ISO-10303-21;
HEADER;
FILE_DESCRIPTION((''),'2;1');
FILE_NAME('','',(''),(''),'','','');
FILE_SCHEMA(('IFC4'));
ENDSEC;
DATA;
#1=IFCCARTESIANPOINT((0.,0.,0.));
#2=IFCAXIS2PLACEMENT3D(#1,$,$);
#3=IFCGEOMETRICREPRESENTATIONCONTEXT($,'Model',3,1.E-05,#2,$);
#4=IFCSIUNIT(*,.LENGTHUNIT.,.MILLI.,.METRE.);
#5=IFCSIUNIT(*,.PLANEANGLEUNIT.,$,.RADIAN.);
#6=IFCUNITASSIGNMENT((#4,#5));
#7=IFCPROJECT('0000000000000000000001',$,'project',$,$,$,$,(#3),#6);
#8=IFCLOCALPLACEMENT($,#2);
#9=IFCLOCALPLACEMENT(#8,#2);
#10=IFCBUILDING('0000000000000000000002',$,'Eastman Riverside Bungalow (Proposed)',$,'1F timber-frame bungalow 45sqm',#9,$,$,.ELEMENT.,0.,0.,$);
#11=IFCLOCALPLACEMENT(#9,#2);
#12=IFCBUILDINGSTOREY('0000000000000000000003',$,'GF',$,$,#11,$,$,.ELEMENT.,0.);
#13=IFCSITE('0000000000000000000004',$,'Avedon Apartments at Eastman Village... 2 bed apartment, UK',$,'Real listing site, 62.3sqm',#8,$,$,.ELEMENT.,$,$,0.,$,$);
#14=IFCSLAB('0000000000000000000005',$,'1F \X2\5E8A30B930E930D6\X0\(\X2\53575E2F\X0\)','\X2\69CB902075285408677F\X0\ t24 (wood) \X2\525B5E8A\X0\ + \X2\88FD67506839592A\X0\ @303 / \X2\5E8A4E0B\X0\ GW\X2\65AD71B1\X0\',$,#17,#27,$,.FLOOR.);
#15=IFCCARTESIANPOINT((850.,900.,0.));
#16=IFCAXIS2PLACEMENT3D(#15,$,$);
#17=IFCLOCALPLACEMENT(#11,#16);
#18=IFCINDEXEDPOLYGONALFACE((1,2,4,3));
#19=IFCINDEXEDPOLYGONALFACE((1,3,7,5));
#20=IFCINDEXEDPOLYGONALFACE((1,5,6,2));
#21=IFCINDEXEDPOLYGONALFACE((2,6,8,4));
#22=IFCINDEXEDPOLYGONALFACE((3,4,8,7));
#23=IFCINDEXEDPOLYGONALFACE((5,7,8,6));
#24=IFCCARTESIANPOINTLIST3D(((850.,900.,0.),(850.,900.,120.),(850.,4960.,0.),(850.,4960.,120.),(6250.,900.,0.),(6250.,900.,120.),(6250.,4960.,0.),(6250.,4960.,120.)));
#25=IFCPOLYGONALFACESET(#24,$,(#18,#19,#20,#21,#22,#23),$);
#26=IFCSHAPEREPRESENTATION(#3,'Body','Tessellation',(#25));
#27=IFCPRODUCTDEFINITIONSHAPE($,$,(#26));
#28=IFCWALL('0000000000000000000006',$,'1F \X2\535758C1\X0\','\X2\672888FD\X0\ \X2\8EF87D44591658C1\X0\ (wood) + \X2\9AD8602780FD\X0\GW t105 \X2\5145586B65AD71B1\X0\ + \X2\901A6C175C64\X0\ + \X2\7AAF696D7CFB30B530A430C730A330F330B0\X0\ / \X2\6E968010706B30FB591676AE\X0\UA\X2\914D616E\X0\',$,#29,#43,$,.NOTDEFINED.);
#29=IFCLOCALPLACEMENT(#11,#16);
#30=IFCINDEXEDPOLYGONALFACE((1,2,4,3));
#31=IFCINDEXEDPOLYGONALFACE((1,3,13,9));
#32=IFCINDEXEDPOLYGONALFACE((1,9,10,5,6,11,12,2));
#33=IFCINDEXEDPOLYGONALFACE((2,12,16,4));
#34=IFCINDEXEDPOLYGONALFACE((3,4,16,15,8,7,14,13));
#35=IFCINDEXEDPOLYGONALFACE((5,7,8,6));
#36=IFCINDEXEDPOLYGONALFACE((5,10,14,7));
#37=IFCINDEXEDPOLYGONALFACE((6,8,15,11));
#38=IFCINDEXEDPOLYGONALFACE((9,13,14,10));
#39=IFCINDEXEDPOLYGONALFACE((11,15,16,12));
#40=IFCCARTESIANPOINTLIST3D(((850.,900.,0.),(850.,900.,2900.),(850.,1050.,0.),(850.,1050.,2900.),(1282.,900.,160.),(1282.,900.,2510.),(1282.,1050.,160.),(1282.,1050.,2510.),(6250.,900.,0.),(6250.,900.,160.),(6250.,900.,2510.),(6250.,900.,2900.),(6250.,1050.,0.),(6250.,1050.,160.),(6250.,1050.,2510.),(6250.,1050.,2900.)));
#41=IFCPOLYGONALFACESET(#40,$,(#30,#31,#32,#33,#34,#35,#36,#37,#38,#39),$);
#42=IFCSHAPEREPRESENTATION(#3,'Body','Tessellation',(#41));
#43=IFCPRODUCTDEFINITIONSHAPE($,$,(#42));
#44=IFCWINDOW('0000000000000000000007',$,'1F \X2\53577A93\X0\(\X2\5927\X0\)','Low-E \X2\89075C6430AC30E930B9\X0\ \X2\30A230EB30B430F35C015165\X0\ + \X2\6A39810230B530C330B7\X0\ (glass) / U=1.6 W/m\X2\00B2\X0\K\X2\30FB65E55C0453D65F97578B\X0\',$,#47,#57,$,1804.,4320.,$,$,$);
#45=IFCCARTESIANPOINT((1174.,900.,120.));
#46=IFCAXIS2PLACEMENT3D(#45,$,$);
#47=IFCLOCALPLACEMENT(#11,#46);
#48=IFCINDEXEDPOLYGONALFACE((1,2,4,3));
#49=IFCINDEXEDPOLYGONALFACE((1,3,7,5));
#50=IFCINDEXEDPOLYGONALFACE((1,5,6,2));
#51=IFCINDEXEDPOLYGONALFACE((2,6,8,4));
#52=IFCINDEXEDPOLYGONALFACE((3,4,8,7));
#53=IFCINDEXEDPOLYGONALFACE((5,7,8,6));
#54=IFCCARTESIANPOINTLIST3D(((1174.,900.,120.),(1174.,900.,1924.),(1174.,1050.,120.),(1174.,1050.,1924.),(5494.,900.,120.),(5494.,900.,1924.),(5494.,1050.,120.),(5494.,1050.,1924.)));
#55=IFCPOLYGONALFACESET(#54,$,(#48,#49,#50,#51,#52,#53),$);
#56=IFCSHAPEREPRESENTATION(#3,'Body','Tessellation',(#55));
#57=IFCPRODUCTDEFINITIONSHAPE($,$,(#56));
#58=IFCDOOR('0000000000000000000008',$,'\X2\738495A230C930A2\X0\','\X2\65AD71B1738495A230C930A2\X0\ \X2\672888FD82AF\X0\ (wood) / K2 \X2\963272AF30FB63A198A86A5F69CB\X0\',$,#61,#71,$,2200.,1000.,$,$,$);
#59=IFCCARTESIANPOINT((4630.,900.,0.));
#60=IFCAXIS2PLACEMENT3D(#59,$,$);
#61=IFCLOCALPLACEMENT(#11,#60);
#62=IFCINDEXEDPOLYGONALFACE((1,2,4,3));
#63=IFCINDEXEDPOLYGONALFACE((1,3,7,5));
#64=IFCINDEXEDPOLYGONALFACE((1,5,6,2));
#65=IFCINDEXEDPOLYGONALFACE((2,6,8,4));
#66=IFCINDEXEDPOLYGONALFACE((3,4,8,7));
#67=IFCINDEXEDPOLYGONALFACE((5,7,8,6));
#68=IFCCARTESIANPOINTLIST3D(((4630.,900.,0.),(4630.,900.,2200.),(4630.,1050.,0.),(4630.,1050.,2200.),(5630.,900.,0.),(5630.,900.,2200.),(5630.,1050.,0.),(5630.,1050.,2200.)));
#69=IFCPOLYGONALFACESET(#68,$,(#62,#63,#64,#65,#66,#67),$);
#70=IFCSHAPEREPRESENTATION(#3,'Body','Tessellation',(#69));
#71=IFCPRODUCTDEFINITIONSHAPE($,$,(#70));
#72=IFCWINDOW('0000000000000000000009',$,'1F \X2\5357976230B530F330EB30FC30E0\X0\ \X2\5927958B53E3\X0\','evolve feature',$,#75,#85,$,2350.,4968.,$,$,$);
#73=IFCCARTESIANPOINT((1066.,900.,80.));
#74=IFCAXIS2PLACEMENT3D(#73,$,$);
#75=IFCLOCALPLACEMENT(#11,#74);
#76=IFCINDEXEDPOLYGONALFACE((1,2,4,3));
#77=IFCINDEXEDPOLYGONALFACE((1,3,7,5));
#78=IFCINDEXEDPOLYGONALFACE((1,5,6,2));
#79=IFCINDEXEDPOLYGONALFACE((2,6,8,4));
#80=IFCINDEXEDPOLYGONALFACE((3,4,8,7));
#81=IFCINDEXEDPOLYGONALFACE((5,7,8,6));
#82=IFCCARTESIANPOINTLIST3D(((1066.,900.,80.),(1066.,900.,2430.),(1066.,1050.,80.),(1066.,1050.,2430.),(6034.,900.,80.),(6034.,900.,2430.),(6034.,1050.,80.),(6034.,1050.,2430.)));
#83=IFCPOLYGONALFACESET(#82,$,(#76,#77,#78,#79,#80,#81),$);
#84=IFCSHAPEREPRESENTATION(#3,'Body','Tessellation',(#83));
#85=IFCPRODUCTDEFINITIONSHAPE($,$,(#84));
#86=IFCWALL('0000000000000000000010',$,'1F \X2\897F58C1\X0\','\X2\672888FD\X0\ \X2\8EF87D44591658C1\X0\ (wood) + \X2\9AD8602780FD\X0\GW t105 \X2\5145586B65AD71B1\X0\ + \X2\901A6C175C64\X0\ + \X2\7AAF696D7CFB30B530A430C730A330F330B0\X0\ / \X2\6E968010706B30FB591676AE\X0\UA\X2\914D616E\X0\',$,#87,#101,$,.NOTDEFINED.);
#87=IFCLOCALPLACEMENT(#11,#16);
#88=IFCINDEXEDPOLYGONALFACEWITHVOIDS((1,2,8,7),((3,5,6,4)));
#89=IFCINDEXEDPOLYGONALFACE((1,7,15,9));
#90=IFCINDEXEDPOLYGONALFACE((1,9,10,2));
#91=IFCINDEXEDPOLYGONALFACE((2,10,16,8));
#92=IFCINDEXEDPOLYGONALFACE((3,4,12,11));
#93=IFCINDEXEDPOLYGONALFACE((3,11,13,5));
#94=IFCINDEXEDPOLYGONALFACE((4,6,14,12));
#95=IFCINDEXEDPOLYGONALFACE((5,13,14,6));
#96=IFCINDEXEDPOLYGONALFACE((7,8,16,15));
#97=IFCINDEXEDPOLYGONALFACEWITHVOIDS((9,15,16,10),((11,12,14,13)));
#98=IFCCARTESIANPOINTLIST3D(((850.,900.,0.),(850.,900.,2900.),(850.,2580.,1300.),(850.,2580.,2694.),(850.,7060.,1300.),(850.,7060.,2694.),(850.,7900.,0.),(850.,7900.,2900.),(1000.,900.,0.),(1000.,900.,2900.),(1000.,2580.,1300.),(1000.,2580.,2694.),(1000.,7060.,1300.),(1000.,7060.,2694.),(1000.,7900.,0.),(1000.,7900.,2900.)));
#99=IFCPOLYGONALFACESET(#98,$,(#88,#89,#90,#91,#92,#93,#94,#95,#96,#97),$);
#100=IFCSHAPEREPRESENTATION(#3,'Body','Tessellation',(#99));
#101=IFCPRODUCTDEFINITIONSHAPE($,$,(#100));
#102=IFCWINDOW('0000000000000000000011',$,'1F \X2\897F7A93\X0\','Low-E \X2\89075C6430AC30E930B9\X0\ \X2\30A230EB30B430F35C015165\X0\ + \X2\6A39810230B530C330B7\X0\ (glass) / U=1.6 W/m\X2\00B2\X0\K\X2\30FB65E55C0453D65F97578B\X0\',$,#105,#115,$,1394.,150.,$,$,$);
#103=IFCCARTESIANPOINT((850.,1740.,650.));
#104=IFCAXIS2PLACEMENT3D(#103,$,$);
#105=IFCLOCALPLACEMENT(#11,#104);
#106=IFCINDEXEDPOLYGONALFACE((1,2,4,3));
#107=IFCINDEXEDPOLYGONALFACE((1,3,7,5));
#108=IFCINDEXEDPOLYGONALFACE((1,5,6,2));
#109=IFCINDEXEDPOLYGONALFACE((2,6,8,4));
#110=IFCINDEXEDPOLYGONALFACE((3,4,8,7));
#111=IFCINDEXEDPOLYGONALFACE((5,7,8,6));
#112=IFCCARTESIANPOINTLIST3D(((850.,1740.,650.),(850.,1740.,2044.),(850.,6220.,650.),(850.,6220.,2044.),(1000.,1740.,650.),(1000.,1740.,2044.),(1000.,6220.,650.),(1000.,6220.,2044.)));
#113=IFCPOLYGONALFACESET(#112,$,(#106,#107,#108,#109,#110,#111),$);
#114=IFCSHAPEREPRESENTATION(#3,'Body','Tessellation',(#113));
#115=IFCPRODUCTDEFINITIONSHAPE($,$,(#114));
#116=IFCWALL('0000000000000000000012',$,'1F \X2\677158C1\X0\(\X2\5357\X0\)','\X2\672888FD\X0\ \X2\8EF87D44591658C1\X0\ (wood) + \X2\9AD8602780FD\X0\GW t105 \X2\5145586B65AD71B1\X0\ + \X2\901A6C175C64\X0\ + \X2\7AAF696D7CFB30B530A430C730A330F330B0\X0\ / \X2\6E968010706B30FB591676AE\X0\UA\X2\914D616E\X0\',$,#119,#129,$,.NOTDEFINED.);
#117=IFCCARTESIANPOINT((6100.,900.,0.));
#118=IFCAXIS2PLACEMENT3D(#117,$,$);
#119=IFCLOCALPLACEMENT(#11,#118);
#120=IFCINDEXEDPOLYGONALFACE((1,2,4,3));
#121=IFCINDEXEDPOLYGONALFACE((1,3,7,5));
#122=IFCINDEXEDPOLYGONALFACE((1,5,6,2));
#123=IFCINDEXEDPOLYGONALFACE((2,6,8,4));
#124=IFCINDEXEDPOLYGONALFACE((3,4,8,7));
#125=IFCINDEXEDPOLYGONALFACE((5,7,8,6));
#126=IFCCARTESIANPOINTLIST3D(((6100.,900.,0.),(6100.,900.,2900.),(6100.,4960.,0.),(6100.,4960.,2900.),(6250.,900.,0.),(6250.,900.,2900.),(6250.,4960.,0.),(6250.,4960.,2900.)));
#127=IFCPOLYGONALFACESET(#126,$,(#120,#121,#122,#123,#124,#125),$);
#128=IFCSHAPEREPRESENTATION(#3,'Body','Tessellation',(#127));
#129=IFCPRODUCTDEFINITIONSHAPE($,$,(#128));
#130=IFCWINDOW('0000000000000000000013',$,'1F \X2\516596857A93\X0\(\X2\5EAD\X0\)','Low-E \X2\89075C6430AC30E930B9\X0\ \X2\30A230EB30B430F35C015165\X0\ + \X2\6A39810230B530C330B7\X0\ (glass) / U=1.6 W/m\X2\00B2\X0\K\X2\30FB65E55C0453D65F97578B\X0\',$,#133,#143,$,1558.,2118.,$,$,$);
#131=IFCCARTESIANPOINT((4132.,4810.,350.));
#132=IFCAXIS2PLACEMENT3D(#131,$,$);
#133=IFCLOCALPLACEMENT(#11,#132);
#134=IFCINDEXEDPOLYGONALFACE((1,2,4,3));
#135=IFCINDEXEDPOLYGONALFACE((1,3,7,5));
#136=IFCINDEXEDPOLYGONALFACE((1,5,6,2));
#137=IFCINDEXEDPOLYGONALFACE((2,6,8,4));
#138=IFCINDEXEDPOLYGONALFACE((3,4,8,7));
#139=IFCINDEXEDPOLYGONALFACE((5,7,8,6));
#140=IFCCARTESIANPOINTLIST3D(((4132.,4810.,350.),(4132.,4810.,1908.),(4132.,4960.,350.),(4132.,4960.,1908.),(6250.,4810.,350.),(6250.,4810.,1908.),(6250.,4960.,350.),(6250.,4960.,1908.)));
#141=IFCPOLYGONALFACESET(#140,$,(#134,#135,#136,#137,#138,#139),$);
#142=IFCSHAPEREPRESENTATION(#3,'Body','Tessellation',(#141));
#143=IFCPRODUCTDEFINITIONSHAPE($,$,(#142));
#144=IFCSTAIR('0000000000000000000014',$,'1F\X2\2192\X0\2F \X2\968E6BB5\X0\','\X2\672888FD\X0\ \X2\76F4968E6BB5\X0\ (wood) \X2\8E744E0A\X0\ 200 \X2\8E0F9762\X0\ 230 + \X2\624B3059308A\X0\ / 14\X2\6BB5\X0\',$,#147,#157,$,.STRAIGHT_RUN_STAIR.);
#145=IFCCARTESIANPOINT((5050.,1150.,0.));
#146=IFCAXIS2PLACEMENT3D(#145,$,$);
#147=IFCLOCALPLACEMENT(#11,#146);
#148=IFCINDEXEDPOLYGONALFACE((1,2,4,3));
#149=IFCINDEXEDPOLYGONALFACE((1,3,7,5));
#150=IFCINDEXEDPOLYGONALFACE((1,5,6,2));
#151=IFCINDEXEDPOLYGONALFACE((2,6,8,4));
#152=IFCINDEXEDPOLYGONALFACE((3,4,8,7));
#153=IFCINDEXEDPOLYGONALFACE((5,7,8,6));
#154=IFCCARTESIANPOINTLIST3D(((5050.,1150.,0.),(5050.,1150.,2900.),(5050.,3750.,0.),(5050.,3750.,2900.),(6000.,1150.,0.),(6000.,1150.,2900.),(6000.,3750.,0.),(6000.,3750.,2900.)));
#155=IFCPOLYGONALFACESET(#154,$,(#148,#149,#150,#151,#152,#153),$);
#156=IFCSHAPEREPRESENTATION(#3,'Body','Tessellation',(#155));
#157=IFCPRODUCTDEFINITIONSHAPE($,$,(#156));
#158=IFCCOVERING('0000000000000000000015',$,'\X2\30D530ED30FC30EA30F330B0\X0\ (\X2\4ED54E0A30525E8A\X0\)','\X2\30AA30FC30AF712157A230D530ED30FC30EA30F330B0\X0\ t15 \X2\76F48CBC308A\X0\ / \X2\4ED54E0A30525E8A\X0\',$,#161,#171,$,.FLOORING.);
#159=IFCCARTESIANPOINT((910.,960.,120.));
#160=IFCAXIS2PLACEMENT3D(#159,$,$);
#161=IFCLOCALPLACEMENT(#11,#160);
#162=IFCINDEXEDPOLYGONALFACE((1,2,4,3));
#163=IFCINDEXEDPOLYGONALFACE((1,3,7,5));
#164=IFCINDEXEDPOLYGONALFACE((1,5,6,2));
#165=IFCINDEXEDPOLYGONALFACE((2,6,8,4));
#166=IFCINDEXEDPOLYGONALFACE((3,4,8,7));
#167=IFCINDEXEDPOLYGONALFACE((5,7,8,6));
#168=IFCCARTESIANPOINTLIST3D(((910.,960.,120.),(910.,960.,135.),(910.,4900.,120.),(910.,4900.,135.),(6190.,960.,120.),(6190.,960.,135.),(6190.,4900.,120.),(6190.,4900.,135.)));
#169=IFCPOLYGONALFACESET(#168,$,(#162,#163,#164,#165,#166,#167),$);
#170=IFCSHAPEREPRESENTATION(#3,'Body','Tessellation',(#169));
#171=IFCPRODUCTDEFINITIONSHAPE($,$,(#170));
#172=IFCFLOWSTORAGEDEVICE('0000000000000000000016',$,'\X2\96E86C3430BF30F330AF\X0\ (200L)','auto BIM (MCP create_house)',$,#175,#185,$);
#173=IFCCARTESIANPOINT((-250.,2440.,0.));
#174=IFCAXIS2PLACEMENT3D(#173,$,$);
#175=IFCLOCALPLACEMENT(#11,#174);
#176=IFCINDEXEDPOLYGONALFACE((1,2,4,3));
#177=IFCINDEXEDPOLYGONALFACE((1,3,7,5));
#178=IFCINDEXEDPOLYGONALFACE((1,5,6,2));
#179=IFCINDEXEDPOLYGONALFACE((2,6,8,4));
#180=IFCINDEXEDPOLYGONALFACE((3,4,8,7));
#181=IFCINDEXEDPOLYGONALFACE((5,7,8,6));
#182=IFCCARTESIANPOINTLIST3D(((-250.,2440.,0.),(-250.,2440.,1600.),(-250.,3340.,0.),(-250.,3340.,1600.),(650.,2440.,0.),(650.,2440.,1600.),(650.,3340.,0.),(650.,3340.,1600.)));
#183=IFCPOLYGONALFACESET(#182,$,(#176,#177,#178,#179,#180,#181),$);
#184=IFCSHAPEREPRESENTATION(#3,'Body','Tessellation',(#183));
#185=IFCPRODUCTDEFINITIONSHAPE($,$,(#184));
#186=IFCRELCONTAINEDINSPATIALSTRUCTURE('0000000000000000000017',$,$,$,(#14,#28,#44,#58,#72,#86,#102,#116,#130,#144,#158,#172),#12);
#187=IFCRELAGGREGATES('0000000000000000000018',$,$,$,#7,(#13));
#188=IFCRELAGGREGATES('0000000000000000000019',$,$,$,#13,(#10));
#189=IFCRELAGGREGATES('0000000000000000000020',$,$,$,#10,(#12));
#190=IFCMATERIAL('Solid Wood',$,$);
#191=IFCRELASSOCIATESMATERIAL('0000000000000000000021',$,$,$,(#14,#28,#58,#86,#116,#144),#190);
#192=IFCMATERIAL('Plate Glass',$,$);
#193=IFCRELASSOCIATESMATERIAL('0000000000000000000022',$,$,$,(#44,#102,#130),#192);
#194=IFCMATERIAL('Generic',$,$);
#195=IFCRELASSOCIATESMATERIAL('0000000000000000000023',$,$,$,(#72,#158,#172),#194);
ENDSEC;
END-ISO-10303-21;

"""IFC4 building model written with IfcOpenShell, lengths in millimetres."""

from ifc_helpers import new_model, si_unit, frame, frame_2d, origin, place, context, project, spatial, rectangle, extrude, material, element, fill, save


model = new_model("IFC4")

# Units and contexts
model_context = context("Model", 3, precision=1e-05, world=origin())
ifc_project = project(units=[si_unit("LENGTHUNIT", "METRE", prefix="MILLI"), si_unit("PLANEANGLEUNIT", "RADIAN")], contexts=[model_context])

# Site, building, storey
site_placement = place(None, origin())
site = spatial("IfcSite", under=ifc_project, at=site_placement, Name="Avedon Apartments at Eastman Village... 2 bed apartment, UK", ObjectType="Real listing site, 62.3sqm", CompositionType="ELEMENT", RefElevation=0.0)
building_placement = place(site_placement, origin())
building = spatial("IfcBuilding", under=site, at=building_placement, Name="Eastman Riverside Bungalow (Proposed)", ObjectType="1F timber-frame bungalow 45sqm", CompositionType="ELEMENT", ElevationOfRefHeight=0.0, ElevationOfTerrain=0.0)
storey_placement = place(building_placement, origin())
storey = spatial("IfcBuildingStorey", under=building, at=storey_placement, Name="GF", CompositionType="ELEMENT", Elevation=0.0)

# Slab
ifc_material_1 = material(Name="Solid Wood")
slab_1_placement = place(storey_placement, frame((850.0, 900.0, 0.0)))
element("IfcSlab", 1, at=slab_1_placement, inside=storey, material=ifc_material_1, Name="1F 床スラブ(南帯)", Description="構造用合板 t24 (wood) 剛床 + 製材根太 @303 / 床下 GW断熱", PredefinedType="FLOOR", context=model_context, shape_type="SweptSolid", body=[
    extrude(rectangle(XDim=5400.0, YDim=4060.0, at=frame_2d((2700.0, 2030.0))), frame((850.0, 900.0, 0.0)), (0.0, 0.0, 1.0), 120.0),
])

# Wall, openings, windows, door
wall_1_placement = place(storey_placement, frame((850.0, 900.0, 0.0)))
wall_1 = element("IfcWall", 2, at=wall_1_placement, inside=storey, material=ifc_material_1, Name="1F 南壁", Description="木製 軸組外壁 (wood) + 高性能GW t105 充填断熱 + 通気層 + 窯業系サイディング / 準耐火・外皮UA配慮", PredefinedType="NOTDEFINED", context=model_context, shape_type="SweptSolid", body=[
    extrude(rectangle(XDim=5400.0, YDim=150.0, at=frame_2d((2700.0, 75.0))), frame((850.0, 900.0, 0.0)), (0.0, 0.0, 1.0), 2900.0),
])
opening_1_placement = place(storey_placement, frame((1174.0, 900.0, 120.0)))
opening_1 = element("IfcOpeningElement", 3, at=opening_1_placement, cuts=wall_1, PredefinedType="NOTDEFINED", context=model_context, shape_type="SweptSolid", body=[
    extrude(rectangle(XDim=4320.0, YDim=150.0, at=frame_2d((2160.0, 75.0))), frame((1174.0, 900.0, 120.0)), (0.0, 0.0, 1.0), 1804.0),
])
opening_2_placement = place(storey_placement, frame((4630.0, 900.0, 0.0)))
opening_2 = element("IfcOpeningElement", 4, at=opening_2_placement, cuts=wall_1, PredefinedType="NOTDEFINED", context=model_context, shape_type="SweptSolid", body=[
    extrude(rectangle(XDim=1000.0, YDim=150.0, at=frame_2d((500.0, 75.0))), frame((4630.0, 900.0, 0.0)), (0.0, 0.0, 1.0), 2200.0),
])
opening_3_placement = place(storey_placement, frame((1066.0, 900.0, 80.0)))
opening_3 = element("IfcOpeningElement", 5, at=opening_3_placement, cuts=wall_1, PredefinedType="NOTDEFINED", context=model_context, shape_type="SweptSolid", body=[
    extrude(rectangle(XDim=4968.0, YDim=150.0, at=frame_2d((2484.0, 75.0))), frame((1066.0, 900.0, 80.0)), (0.0, 0.0, 1.0), 2350.0),
])
ifc_material_2 = material(Name="Plate Glass")
window_1_placement = place(storey_placement, frame((1174.0, 900.0, 120.0)))
window_1 = element("IfcWindow", 6, at=window_1_placement, inside=storey, material=ifc_material_2, Name="1F 南窓(大)", Description="Low-E 複層ガラス アルゴン封入 + 樹脂サッシ (glass) / U=1.6 W/m²K・日射取得型", OverallHeight=1804.0, OverallWidth=4320.0, context=model_context, shape_type="SweptSolid", body=[
    extrude(rectangle(XDim=4320.0, YDim=150.0, at=frame_2d((2160.0, 75.0))), frame((1174.0, 900.0, 120.0)), (0.0, 0.0, 1.0), 1804.0),
])
fill(opening_1, window_1)
door_1_placement = place(storey_placement, frame((4630.0, 900.0, 0.0)))
door_1 = element("IfcDoor", 7, at=door_1_placement, inside=storey, material=ifc_material_1, Name="玄関ドア", Description="断熱玄関ドア 木製芯 (wood) / K2 防犯・採風機構", OverallHeight=2200.0, OverallWidth=1000.0, context=model_context, shape_type="SweptSolid", body=[
    extrude(rectangle(XDim=1000.0, YDim=150.0, at=frame_2d((500.0, 75.0))), frame((4630.0, 900.0, 0.0)), (0.0, 0.0, 1.0), 2200.0),
])
fill(opening_2, door_1)
ifc_material_3 = material(Name="Generic")
window_2_placement = place(storey_placement, frame((1066.0, 900.0, 80.0)))
window_2 = element("IfcWindow", 8, at=window_2_placement, inside=storey, material=ifc_material_3, Name="1F 南面サンルーム 大開口", Description="evolve feature", OverallHeight=2350.0, OverallWidth=4968.0, context=model_context, shape_type="SweptSolid", body=[
    extrude(rectangle(XDim=4968.0, YDim=150.0, at=frame_2d((2484.0, 75.0))), frame((1066.0, 900.0, 80.0)), (0.0, 0.0, 1.0), 2350.0),
])
fill(opening_3, window_2)

# Walls, openings, windows
wall_2_placement = place(storey_placement, frame((850.0, 900.0, 0.0)))
wall_2 = element("IfcWall", 9, at=wall_2_placement, inside=storey, material=ifc_material_1, Name="1F 西壁", Description="木製 軸組外壁 (wood) + 高性能GW t105 充填断熱 + 通気層 + 窯業系サイディング / 準耐火・外皮UA配慮", PredefinedType="NOTDEFINED", context=model_context, shape_type="SweptSolid", body=[
    extrude(rectangle(XDim=150.0, YDim=7000.0, at=frame_2d((75.0, 3500.0))), frame((850.0, 900.0, 0.0)), (0.0, 0.0, 1.0), 2900.0),
])
opening_4_placement = place(storey_placement, frame((850.0, 1740.0, 650.0)))
opening_4 = element("IfcOpeningElement", 10, at=opening_4_placement, cuts=wall_2, PredefinedType="NOTDEFINED", context=model_context, shape_type="SweptSolid", body=[
    extrude(rectangle(XDim=150.0, YDim=4480.0, at=frame_2d((75.0, 2240.0))), frame((850.0, 1740.0, 650.0)), (0.0, 0.0, 1.0), 1394.0),
])
window_3_placement = place(storey_placement, frame((850.0, 1740.0, 650.0)))
window_3 = element("IfcWindow", 11, at=window_3_placement, inside=storey, material=ifc_material_2, Name="1F 西窓", Description="Low-E 複層ガラス アルゴン封入 + 樹脂サッシ (glass) / U=1.6 W/m²K・日射取得型", OverallHeight=1394.0, OverallWidth=150.0, context=model_context, shape_type="SweptSolid", body=[
    extrude(rectangle(XDim=150.0, YDim=4480.0, at=frame_2d((75.0, 2240.0))), frame((850.0, 1740.0, 650.0)), (0.0, 0.0, 1.0), 1394.0),
])
fill(opening_4, window_3)
wall_3_placement = place(storey_placement, frame((6100.0, 900.0, 0.0)))
wall_3 = element("IfcWall", 12, at=wall_3_placement, inside=storey, material=ifc_material_1, Name="1F 東壁(南)", Description="木製 軸組外壁 (wood) + 高性能GW t105 充填断熱 + 通気層 + 窯業系サイディング / 準耐火・外皮UA配慮", PredefinedType="NOTDEFINED", context=model_context, shape_type="SweptSolid", body=[
    extrude(rectangle(XDim=150.0, YDim=4060.0, at=frame_2d((75.0, 2030.0))), frame((6100.0, 900.0, 0.0)), (0.0, 0.0, 1.0), 2900.0),
])
opening_5_placement = place(storey_placement, frame((4132.0, 4810.0, 350.0)))
opening_5 = element("IfcOpeningElement", 13, at=opening_5_placement, cuts=wall_3, PredefinedType="NOTDEFINED", context=model_context, shape_type="SweptSolid", body=[
    extrude(rectangle(XDim=2118.0, YDim=150.0, at=frame_2d((1059.0, 75.0))), frame((4132.0, 4810.0, 350.0)), (0.0, 0.0, 1.0), 1558.0),
])
window_4_placement = place(storey_placement, frame((4132.0, 4810.0, 350.0)))
window_4 = element("IfcWindow", 14, at=window_4_placement, inside=storey, material=ifc_material_2, Name="1F 入隅窓(庭)", Description="Low-E 複層ガラス アルゴン封入 + 樹脂サッシ (glass) / U=1.6 W/m²K・日射取得型", OverallHeight=1558.0, OverallWidth=2118.0, context=model_context, shape_type="SweptSolid", body=[
    extrude(rectangle(XDim=2118.0, YDim=150.0, at=frame_2d((1059.0, 75.0))), frame((4132.0, 4810.0, 350.0)), (0.0, 0.0, 1.0), 1558.0),
])
fill(opening_5, window_4)

# Stair
stair_placement = place(storey_placement, frame((5050.0, 1150.0, 0.0)))
element("IfcStair", 15, at=stair_placement, inside=storey, material=ifc_material_1, Name="1F→2F 階段", Description="木製 直階段 (wood) 蹴上 200 踏面 230 + 手すり / 14段", PredefinedType="STRAIGHT_RUN_STAIR", context=model_context, shape_type="SweptSolid", body=[
    extrude(rectangle(XDim=950.0, YDim=2600.0, at=frame_2d((475.0, 1300.0))), frame((5050.0, 1150.0, 0.0)), (0.0, 0.0, 1.0), 2900.0),
])

# Covering
covering_placement = place(storey_placement, frame((910.0, 960.0, 120.0)))
element("IfcCovering", 16, at=covering_placement, inside=storey, material=ifc_material_3, Name="フローリング (仕上げ床)", Description="オーク無垢フローリング t15 直貼り / 仕上げ床", PredefinedType="FLOORING", context=model_context, shape_type="SweptSolid", body=[
    extrude(rectangle(XDim=5280.0, YDim=3940.0, at=frame_2d((2640.0, 1970.0))), frame((910.0, 960.0, 120.0)), (0.0, 0.0, 1.0), 15.0),
])

# Flow storage device
flow_storage_device_placement = place(storey_placement, frame((-250.0, 2440.0, 0.0)))
element("IfcFlowStorageDevice", 17, at=flow_storage_device_placement, inside=storey, material=ifc_material_3, Name="雨水タンク (200L)", Description="auto BIM (MCP create_house)", context=model_context, shape_type="SweptSolid", body=[
    extrude(rectangle(XDim=900.0, YDim=900.0, at=frame_2d((450.0, 450.0))), frame((-250.0, 2440.0, 0.0)), (0.0, 0.0, 1.0), 1600.0),
])

save(model, "model.ifc")
